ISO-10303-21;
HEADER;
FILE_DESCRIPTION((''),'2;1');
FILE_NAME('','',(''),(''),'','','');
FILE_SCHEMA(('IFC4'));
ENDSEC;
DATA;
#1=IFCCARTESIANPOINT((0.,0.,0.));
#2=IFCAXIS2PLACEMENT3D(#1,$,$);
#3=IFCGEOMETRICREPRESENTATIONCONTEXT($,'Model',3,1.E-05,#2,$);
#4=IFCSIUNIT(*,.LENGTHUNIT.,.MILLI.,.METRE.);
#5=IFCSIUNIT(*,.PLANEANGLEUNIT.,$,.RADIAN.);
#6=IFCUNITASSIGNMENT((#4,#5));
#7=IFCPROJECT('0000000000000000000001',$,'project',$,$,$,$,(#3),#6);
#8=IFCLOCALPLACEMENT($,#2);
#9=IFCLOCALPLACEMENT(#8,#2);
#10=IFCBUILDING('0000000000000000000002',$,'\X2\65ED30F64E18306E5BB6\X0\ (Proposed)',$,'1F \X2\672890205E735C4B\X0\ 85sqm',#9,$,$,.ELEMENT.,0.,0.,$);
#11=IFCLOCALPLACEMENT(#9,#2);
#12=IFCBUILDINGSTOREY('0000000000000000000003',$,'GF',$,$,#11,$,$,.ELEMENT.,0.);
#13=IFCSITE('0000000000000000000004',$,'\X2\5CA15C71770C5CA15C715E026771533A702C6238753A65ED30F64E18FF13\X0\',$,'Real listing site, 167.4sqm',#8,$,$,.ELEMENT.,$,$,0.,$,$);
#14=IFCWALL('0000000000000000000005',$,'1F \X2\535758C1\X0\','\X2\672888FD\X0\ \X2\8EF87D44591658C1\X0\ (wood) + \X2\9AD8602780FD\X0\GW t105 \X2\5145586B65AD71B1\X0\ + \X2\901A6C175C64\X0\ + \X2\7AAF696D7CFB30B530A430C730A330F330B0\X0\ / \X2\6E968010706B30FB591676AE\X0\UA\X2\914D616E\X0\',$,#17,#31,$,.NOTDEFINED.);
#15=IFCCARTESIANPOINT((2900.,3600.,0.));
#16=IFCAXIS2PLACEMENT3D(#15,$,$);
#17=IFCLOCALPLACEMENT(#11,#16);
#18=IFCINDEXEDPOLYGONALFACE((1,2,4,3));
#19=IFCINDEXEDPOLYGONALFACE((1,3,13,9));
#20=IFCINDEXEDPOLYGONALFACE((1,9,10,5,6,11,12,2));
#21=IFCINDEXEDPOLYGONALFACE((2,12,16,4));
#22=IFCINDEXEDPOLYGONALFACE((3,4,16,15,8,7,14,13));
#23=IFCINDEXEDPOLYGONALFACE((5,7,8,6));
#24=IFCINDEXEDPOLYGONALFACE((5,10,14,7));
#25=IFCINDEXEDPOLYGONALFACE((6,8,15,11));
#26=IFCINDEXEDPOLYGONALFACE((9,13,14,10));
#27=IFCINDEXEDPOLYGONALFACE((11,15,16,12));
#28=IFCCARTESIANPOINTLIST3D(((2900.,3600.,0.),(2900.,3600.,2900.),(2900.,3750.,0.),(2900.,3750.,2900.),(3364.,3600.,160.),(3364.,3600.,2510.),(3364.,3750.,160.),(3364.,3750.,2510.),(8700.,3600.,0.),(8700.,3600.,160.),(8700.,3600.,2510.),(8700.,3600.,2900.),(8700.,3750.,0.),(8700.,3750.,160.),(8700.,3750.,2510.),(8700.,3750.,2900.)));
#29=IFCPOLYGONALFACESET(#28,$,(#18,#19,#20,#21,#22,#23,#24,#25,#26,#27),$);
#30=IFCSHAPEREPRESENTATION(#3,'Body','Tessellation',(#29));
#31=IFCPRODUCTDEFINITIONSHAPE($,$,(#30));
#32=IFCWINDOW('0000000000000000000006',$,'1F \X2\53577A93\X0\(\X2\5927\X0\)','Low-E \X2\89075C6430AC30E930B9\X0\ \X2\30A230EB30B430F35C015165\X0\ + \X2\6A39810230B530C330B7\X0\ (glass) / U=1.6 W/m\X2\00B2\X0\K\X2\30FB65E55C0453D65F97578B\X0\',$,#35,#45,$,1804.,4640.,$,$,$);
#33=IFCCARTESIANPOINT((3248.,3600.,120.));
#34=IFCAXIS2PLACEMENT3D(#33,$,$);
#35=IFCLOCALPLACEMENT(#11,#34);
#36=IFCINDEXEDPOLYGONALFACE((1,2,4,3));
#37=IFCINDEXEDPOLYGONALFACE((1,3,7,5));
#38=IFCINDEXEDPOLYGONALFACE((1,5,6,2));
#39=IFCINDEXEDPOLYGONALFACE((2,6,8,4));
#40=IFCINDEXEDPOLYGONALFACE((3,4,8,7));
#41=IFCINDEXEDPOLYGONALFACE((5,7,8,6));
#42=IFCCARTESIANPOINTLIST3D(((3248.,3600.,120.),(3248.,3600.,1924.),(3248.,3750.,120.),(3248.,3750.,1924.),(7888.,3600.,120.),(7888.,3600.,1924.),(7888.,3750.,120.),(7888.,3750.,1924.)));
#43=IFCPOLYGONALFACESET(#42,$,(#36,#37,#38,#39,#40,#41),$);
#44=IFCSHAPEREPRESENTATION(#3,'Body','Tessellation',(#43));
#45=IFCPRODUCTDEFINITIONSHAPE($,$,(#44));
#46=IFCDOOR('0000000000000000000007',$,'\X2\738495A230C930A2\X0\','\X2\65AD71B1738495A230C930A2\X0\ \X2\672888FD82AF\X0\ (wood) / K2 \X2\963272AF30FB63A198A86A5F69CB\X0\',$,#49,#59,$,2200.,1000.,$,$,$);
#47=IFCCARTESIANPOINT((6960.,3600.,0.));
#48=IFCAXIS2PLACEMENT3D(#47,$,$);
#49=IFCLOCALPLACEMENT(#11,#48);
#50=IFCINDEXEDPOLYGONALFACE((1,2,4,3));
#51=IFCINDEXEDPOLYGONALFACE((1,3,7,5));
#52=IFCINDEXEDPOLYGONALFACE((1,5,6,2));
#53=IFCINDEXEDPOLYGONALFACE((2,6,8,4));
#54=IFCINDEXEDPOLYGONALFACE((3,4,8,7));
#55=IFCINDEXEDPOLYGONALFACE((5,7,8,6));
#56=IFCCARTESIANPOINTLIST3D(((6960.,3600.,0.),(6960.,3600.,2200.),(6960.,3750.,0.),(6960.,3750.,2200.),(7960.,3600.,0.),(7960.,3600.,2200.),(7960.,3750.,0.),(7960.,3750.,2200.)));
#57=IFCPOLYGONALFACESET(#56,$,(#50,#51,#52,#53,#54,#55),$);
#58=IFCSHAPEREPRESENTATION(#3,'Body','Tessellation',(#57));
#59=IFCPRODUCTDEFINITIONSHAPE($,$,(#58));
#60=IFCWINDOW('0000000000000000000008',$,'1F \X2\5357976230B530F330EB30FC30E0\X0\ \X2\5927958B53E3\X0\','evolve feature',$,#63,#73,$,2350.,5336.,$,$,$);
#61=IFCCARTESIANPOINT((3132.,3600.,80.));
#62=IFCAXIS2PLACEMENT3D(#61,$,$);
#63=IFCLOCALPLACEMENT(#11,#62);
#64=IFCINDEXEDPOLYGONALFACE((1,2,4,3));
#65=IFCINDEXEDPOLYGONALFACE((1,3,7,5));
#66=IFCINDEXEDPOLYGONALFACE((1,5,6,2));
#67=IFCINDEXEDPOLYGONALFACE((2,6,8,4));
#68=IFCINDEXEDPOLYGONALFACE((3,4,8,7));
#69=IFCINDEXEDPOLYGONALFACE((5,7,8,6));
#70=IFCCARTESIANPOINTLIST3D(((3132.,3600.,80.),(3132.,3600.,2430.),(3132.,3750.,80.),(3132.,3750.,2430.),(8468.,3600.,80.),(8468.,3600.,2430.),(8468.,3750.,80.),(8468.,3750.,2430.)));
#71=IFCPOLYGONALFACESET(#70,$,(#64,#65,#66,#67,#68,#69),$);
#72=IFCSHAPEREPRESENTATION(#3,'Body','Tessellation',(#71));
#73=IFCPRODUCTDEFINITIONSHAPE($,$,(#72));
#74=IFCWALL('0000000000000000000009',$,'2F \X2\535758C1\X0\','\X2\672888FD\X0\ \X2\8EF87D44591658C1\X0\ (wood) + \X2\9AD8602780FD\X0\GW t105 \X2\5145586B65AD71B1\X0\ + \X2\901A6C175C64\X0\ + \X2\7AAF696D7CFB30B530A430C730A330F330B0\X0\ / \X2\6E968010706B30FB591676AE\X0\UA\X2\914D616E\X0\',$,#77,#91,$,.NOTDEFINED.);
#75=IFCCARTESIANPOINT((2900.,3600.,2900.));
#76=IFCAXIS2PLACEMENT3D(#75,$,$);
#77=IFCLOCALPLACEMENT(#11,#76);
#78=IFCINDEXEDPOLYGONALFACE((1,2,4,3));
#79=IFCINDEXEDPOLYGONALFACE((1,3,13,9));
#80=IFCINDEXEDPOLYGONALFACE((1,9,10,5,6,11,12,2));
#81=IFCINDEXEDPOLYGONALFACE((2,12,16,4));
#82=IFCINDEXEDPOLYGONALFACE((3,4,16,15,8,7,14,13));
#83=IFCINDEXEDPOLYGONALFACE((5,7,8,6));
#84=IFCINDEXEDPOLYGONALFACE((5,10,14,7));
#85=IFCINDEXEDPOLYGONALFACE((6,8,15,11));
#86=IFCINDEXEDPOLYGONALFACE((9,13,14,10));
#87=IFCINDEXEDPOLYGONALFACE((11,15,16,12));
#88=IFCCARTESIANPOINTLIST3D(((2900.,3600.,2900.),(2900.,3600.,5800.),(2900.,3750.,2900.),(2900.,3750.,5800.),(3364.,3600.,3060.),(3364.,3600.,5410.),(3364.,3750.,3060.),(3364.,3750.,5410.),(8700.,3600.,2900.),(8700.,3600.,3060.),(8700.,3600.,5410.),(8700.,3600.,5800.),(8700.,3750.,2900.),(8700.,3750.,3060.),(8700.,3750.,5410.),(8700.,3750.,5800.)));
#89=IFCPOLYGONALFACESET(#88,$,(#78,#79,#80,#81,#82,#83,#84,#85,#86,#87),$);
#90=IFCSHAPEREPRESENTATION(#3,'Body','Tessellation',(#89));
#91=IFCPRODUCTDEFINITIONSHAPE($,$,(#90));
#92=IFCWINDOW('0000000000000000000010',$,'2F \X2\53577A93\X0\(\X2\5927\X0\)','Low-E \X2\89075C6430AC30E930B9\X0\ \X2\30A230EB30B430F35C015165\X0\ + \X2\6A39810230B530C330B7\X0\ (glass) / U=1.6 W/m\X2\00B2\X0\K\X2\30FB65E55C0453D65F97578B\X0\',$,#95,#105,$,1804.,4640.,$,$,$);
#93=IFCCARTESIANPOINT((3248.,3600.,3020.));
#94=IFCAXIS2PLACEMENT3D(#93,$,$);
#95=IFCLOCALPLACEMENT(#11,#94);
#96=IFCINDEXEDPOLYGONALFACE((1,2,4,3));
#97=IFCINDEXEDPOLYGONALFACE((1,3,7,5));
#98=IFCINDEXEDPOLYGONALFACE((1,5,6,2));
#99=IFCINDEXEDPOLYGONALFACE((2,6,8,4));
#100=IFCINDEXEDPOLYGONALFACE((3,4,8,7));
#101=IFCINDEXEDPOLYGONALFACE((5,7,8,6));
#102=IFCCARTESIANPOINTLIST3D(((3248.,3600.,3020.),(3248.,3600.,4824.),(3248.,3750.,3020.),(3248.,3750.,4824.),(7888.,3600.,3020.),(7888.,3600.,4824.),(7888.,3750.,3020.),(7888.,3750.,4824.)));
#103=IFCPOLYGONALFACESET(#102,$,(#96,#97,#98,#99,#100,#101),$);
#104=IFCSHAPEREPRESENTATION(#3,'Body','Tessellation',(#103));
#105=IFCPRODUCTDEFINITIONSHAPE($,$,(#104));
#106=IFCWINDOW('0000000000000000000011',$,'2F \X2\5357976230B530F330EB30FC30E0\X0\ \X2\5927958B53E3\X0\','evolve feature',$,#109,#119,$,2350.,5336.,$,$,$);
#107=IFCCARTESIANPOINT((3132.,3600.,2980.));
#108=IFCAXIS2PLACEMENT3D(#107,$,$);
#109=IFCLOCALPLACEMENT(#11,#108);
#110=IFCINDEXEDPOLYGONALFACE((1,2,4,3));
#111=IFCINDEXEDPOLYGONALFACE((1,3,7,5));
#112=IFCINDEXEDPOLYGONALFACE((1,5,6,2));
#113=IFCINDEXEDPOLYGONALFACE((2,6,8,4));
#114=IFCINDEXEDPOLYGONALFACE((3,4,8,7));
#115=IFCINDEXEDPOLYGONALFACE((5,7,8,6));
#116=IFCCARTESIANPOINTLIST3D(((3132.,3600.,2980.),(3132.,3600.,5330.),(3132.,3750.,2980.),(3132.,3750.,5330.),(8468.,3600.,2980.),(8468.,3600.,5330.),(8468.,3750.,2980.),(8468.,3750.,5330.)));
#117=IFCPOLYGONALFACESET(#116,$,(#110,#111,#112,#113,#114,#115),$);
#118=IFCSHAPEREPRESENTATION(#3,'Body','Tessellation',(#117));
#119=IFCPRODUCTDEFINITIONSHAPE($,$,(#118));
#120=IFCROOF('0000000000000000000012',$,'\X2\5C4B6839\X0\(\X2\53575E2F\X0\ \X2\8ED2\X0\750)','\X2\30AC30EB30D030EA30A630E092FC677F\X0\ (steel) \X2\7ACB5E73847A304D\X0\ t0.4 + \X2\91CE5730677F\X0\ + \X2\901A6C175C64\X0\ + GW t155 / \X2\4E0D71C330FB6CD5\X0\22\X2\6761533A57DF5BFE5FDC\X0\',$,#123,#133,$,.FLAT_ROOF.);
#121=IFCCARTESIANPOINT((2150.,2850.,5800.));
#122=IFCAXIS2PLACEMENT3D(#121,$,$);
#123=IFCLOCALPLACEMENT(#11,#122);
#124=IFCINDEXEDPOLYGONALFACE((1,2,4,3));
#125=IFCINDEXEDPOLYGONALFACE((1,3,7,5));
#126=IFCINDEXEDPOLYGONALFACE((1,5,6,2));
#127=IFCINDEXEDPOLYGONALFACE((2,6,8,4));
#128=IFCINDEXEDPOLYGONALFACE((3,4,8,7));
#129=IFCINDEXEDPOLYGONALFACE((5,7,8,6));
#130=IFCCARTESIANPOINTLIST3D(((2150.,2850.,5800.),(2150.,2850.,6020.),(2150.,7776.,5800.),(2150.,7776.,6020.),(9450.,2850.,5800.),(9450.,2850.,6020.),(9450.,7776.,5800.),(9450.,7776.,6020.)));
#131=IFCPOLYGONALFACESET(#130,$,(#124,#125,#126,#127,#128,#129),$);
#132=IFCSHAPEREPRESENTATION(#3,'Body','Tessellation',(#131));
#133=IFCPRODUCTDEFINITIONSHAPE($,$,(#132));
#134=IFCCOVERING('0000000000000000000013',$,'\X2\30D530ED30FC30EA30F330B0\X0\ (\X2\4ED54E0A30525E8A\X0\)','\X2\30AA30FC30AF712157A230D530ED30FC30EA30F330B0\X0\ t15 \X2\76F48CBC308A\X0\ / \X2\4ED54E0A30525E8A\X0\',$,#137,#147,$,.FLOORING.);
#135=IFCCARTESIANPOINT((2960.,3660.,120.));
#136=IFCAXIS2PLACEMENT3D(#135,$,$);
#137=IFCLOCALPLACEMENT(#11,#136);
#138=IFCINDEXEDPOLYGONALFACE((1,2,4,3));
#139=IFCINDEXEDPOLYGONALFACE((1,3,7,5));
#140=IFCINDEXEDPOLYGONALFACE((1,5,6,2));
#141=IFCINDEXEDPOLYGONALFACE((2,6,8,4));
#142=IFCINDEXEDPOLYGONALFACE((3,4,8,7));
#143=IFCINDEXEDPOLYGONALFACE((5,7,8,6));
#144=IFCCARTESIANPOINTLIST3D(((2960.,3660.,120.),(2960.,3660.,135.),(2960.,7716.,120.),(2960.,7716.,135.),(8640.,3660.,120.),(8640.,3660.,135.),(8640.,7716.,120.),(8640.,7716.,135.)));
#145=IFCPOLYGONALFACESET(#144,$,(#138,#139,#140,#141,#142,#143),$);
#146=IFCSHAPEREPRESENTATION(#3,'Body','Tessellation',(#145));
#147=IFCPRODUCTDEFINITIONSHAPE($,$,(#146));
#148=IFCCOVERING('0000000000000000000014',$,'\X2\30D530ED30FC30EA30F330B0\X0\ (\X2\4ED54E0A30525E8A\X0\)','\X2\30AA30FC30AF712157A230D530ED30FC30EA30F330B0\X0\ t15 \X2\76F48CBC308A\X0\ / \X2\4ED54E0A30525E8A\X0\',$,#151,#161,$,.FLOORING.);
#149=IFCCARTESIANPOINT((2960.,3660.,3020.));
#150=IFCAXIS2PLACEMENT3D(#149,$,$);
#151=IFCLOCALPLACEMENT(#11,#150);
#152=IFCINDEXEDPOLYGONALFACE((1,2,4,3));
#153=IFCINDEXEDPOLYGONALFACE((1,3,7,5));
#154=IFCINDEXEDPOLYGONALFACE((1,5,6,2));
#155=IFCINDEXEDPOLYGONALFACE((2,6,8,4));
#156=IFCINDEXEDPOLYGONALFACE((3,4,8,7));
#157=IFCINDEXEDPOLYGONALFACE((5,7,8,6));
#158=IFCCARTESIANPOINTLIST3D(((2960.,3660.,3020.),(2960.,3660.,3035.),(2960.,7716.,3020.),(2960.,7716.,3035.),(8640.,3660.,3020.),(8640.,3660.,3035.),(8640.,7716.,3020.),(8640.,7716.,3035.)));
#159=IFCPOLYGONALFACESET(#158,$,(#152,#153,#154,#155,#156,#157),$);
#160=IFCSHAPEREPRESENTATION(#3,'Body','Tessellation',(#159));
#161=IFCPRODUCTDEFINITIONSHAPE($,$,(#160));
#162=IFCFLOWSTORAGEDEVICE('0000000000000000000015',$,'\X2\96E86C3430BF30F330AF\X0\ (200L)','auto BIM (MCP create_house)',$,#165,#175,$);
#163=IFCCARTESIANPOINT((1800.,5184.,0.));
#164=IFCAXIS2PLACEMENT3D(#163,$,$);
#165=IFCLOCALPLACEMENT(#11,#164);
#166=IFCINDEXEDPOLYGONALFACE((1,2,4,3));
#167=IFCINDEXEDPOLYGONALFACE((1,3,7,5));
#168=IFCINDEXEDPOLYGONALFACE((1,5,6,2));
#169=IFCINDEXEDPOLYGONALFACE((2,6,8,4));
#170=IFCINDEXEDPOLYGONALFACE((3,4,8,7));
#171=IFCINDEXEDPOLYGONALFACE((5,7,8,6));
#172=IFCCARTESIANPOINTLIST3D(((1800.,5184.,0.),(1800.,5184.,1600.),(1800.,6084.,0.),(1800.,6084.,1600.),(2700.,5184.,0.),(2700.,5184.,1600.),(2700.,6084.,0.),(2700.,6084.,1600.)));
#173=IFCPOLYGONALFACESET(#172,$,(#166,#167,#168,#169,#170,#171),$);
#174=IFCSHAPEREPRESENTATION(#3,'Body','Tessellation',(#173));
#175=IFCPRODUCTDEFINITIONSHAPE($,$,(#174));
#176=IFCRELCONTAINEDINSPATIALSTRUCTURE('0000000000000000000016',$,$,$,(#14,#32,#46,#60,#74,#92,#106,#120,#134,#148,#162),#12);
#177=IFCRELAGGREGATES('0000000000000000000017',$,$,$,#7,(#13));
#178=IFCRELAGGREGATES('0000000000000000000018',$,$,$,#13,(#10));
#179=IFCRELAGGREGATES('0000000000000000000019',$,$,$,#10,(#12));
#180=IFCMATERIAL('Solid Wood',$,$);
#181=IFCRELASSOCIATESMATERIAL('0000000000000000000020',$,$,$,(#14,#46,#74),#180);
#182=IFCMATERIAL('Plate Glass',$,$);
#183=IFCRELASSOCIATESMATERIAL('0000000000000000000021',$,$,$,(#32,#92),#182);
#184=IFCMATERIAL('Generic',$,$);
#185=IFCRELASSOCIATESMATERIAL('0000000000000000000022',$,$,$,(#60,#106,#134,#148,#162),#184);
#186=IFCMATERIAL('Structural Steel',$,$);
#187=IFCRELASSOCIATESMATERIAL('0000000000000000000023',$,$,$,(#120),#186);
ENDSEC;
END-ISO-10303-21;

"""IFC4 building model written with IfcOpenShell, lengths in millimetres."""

from ifc_helpers import new_model, si_unit, frame, frame_2d, origin, place, context, project, spatial, rectangle, extrude, material, element, fill, save


model = new_model("IFC4")

# Units and contexts
model_context = context("Model", 3, precision=1e-05, world=origin())
ifc_project = project(units=[si_unit("LENGTHUNIT", "METRE", prefix="MILLI"), si_unit("PLANEANGLEUNIT", "RADIAN")], contexts=[model_context])

# Site, building, storey
site_placement = place(None, origin())
site = spatial("IfcSite", under=ifc_project, at=site_placement, Name="岡山県岡山市東区瀬戸町旭ヶ丘３", ObjectType="Real listing site, 167.4sqm", CompositionType="ELEMENT", RefElevation=0.0)
building_placement = place(site_placement, origin())
building = spatial("IfcBuilding", under=site, at=building_placement, Name="旭ヶ丘の家 (Proposed)", ObjectType="1F 木造平屋 85sqm", CompositionType="ELEMENT", ElevationOfRefHeight=0.0, ElevationOfTerrain=0.0)
storey_placement = place(building_placement, origin())
storey = spatial("IfcBuildingStorey", under=building, at=storey_placement, Name="GF", CompositionType="ELEMENT", Elevation=0.0)

# Shared definitions
ifc_material_1 = material(Name="Solid Wood")
ifc_material_2 = material(Name="Generic")

# Wall, openings, windows, door
wall_1_placement = place(storey_placement, frame((2900.0, 3600.0, 0.0)))
wall_1 = element("IfcWall", 1, at=wall_1_placement, inside=storey, material=ifc_material_1, Name="1F 南壁", Description="木製 軸組外壁 (wood) + 高性能GW t105 充填断熱 + 通気層 + 窯業系サイディング / 準耐火・外皮UA配慮", PredefinedType="NOTDEFINED", context=model_context, shape_type="SweptSolid", body=[
    extrude(rectangle(XDim=5800.0, YDim=150.0, at=frame_2d((2900.0, 75.0))), frame((2900.0, 3600.0, 0.0)), (0.0, 0.0, 1.0), 2900.0),
])
opening_1_placement = place(storey_placement, frame((3248.0, 3600.0, 120.0)))
opening_1 = element("IfcOpeningElement", 2, at=opening_1_placement, cuts=wall_1, PredefinedType="NOTDEFINED", context=model_context, shape_type="SweptSolid", body=[
    extrude(rectangle(XDim=4640.0, YDim=150.0, at=frame_2d((2320.0, 75.0))), frame((3248.0, 3600.0, 120.0)), (0.0, 0.0, 1.0), 1804.0),
])
opening_2_placement = place(storey_placement, frame((6960.0, 3600.0, 0.0)))
opening_2 = element("IfcOpeningElement", 3, at=opening_2_placement, cuts=wall_1, PredefinedType="NOTDEFINED", context=model_context, shape_type="SweptSolid", body=[
    extrude(rectangle(XDim=1000.0, YDim=150.0, at=frame_2d((500.0, 75.0))), frame((6960.0, 3600.0, 0.0)), (0.0, 0.0, 1.0), 2200.0),
])
opening_3_placement = place(storey_placement, frame((3132.0, 3600.0, 80.0)))
opening_3 = element("IfcOpeningElement", 4, at=opening_3_placement, cuts=wall_1, PredefinedType="NOTDEFINED", context=model_context, shape_type="SweptSolid", body=[
    extrude(rectangle(XDim=5336.0, YDim=150.0, at=frame_2d((2668.0, 75.0))), frame((3132.0, 3600.0, 80.0)), (0.0, 0.0, 1.0), 2350.0),
])
ifc_material_3 = material(Name="Plate Glass")
window_1_placement = place(storey_placement, frame((3248.0, 3600.0, 120.0)))
window_1 = element("IfcWindow", 5, at=window_1_placement, inside=storey, material=ifc_material_3, Name="1F 南窓(大)", Description="Low-E 複層ガラス アルゴン封入 + 樹脂サッシ (glass) / U=1.6 W/m²K・日射取得型", OverallHeight=1804.0, OverallWidth=4640.0, context=model_context, shape_type="SweptSolid", body=[
    extrude(rectangle(XDim=4640.0, YDim=150.0, at=frame_2d((2320.0, 75.0))), frame((3248.0, 3600.0, 120.0)), (0.0, 0.0, 1.0), 1804.0),
])
fill(opening_1, window_1)
door_placement = place(storey_placement, frame((6960.0, 3600.0, 0.0)))
door = element("IfcDoor", 6, at=door_placement, inside=storey, material=ifc_material_1, Name="玄関ドア", Description="断熱玄関ドア 木製芯 (wood) / K2 防犯・採風機構", OverallHeight=2200.0, OverallWidth=1000.0, context=model_context, shape_type="SweptSolid", body=[
    extrude(rectangle(XDim=1000.0, YDim=150.0, at=frame_2d((500.0, 75.0))), frame((6960.0, 3600.0, 0.0)), (0.0, 0.0, 1.0), 2200.0),
])
fill(opening_2, door)
window_2_placement = place(storey_placement, frame((3132.0, 3600.0, 80.0)))
window_2 = element("IfcWindow", 7, at=window_2_placement, inside=storey, material=ifc_material_2, Name="1F 南面サンルーム 大開口", Description="evolve feature", OverallHeight=2350.0, OverallWidth=5336.0, context=model_context, shape_type="SweptSolid", body=[
    extrude(rectangle(XDim=5336.0, YDim=150.0, at=frame_2d((2668.0, 75.0))), frame((3132.0, 3600.0, 80.0)), (0.0, 0.0, 1.0), 2350.0),
])
fill(opening_3, window_2)

# Wall, openings, windows
wall_2_placement = place(storey_placement, frame((2900.0, 3600.0, 2900.0)))
wall_2 = element("IfcWall", 8, at=wall_2_placement, inside=storey, material=ifc_material_1, Name="2F 南壁", Description="木製 軸組外壁 (wood) + 高性能GW t105 充填断熱 + 通気層 + 窯業系サイディング / 準耐火・外皮UA配慮", PredefinedType="NOTDEFINED", context=model_context, shape_type="SweptSolid", body=[
    extrude(rectangle(XDim=5800.0, YDim=150.0, at=frame_2d((2900.0, 75.0))), frame((2900.0, 3600.0, 2900.0)), (0.0, 0.0, 1.0), 2900.0),
])
opening_4_placement = place(storey_placement, frame((3248.0, 3600.0, 3020.0)))
opening_4 = element("IfcOpeningElement", 9, at=opening_4_placement, cuts=wall_2, PredefinedType="NOTDEFINED", context=model_context, shape_type="SweptSolid", body=[
    extrude(rectangle(XDim=4640.0, YDim=150.0, at=frame_2d((2320.0, 75.0))), frame((3248.0, 3600.0, 3020.0)), (0.0, 0.0, 1.0), 1804.0),
])
opening_5_placement = place(storey_placement, frame((3132.0, 3600.0, 2980.0)))
opening_5 = element("IfcOpeningElement", 10, at=opening_5_placement, cuts=wall_2, PredefinedType="NOTDEFINED", context=model_context, shape_type="SweptSolid", body=[
    extrude(rectangle(XDim=5336.0, YDim=150.0, at=frame_2d((2668.0, 75.0))), frame((3132.0, 3600.0, 2980.0)), (0.0, 0.0, 1.0), 2350.0),
])
window_3_placement = place(storey_placement, frame((3248.0, 3600.0, 3020.0)))
window_3 = element("IfcWindow", 11, at=window_3_placement, inside=storey, material=ifc_material_3, Name="2F 南窓(大)", Description="Low-E 複層ガラス アルゴン封入 + 樹脂サッシ (glass) / U=1.6 W/m²K・日射取得型", OverallHeight=1804.0, OverallWidth=4640.0, context=model_context, shape_type="SweptSolid", body=[
    extrude(rectangle(XDim=4640.0, YDim=150.0, at=frame_2d((2320.0, 75.0))), frame((3248.0, 3600.0, 3020.0)), (0.0, 0.0, 1.0), 1804.0),
])
fill(opening_4, window_3)
window_4_placement = place(storey_placement, frame((3132.0, 3600.0, 2980.0)))
window_4 = element("IfcWindow", 12, at=window_4_placement, inside=storey, material=ifc_material_2, Name="2F 南面サンルーム 大開口", Description="evolve feature", OverallHeight=2350.0, OverallWidth=5336.0, context=model_context, shape_type="SweptSolid", body=[
    extrude(rectangle(XDim=5336.0, YDim=150.0, at=frame_2d((2668.0, 75.0))), frame((3132.0, 3600.0, 2980.0)), (0.0, 0.0, 1.0), 2350.0),
])
fill(opening_5, window_4)

# Roof
ifc_material_4 = material(Name="Structural Steel")
for number, where, name in (
    (13, (2150.0, 2850.0, 5800.0), "屋根(南帯 軒750)"),
):
    element("IfcRoof", number, at=place(storey_placement, frame(where)), inside=storey, material=ifc_material_4, Name=name, Description="ガルバリウム鋼板 (steel) 立平葺き t0.4 + 野地板 + 通気層 + GW t155 / 不燃・法22条区域対応", PredefinedType="FLAT_ROOF", context=model_context, shape_type="SweptSolid", body=[
        extrude(rectangle(XDim=7300.0, YDim=4926.0, at=frame_2d((3650.0, 2463.0))), frame((2150.0, 2850.0, 5800.0)), (0.0, 0.0, 1.0), 220.0),
    ])

# Coverings
covering_1_placement = place(storey_placement, frame((2960.0, 3660.0, 120.0)))
element("IfcCovering", 14, at=covering_1_placement, inside=storey, material=ifc_material_2, Name="フローリング (仕上げ床)", Description="オーク無垢フローリング t15 直貼り / 仕上げ床", PredefinedType="FLOORING", context=model_context, shape_type="SweptSolid", body=[
    extrude(rectangle(XDim=5680.0, YDim=4056.0, at=frame_2d((2840.0, 2028.0))), frame((2960.0, 3660.0, 120.0)), (0.0, 0.0, 1.0), 15.0),
])
covering_2_placement = place(storey_placement, frame((2960.0, 3660.0, 3020.0)))
element("IfcCovering", 15, at=covering_2_placement, inside=storey, material=ifc_material_2, Name="フローリング (仕上げ床)", Description="オーク無垢フローリング t15 直貼り / 仕上げ床", PredefinedType="FLOORING", context=model_context, shape_type="SweptSolid", body=[
    extrude(rectangle(XDim=5680.0, YDim=4056.0, at=frame_2d((2840.0, 2028.0))), frame((2960.0, 3660.0, 3020.0)), (0.0, 0.0, 1.0), 15.0),
])

# Flow storage device
flow_storage_device_placement = place(storey_placement, frame((1800.0, 5184.0, 0.0)))
element("IfcFlowStorageDevice", 16, at=flow_storage_device_placement, inside=storey, material=ifc_material_2, Name="雨水タンク (200L)", Description="auto BIM (MCP create_house)", context=model_context, shape_type="SweptSolid", body=[
    extrude(rectangle(XDim=900.0, YDim=900.0, at=frame_2d((450.0, 450.0))), frame((1800.0, 5184.0, 0.0)), (0.0, 0.0, 1.0), 1600.0),
])

save(model, "model.ifc")
